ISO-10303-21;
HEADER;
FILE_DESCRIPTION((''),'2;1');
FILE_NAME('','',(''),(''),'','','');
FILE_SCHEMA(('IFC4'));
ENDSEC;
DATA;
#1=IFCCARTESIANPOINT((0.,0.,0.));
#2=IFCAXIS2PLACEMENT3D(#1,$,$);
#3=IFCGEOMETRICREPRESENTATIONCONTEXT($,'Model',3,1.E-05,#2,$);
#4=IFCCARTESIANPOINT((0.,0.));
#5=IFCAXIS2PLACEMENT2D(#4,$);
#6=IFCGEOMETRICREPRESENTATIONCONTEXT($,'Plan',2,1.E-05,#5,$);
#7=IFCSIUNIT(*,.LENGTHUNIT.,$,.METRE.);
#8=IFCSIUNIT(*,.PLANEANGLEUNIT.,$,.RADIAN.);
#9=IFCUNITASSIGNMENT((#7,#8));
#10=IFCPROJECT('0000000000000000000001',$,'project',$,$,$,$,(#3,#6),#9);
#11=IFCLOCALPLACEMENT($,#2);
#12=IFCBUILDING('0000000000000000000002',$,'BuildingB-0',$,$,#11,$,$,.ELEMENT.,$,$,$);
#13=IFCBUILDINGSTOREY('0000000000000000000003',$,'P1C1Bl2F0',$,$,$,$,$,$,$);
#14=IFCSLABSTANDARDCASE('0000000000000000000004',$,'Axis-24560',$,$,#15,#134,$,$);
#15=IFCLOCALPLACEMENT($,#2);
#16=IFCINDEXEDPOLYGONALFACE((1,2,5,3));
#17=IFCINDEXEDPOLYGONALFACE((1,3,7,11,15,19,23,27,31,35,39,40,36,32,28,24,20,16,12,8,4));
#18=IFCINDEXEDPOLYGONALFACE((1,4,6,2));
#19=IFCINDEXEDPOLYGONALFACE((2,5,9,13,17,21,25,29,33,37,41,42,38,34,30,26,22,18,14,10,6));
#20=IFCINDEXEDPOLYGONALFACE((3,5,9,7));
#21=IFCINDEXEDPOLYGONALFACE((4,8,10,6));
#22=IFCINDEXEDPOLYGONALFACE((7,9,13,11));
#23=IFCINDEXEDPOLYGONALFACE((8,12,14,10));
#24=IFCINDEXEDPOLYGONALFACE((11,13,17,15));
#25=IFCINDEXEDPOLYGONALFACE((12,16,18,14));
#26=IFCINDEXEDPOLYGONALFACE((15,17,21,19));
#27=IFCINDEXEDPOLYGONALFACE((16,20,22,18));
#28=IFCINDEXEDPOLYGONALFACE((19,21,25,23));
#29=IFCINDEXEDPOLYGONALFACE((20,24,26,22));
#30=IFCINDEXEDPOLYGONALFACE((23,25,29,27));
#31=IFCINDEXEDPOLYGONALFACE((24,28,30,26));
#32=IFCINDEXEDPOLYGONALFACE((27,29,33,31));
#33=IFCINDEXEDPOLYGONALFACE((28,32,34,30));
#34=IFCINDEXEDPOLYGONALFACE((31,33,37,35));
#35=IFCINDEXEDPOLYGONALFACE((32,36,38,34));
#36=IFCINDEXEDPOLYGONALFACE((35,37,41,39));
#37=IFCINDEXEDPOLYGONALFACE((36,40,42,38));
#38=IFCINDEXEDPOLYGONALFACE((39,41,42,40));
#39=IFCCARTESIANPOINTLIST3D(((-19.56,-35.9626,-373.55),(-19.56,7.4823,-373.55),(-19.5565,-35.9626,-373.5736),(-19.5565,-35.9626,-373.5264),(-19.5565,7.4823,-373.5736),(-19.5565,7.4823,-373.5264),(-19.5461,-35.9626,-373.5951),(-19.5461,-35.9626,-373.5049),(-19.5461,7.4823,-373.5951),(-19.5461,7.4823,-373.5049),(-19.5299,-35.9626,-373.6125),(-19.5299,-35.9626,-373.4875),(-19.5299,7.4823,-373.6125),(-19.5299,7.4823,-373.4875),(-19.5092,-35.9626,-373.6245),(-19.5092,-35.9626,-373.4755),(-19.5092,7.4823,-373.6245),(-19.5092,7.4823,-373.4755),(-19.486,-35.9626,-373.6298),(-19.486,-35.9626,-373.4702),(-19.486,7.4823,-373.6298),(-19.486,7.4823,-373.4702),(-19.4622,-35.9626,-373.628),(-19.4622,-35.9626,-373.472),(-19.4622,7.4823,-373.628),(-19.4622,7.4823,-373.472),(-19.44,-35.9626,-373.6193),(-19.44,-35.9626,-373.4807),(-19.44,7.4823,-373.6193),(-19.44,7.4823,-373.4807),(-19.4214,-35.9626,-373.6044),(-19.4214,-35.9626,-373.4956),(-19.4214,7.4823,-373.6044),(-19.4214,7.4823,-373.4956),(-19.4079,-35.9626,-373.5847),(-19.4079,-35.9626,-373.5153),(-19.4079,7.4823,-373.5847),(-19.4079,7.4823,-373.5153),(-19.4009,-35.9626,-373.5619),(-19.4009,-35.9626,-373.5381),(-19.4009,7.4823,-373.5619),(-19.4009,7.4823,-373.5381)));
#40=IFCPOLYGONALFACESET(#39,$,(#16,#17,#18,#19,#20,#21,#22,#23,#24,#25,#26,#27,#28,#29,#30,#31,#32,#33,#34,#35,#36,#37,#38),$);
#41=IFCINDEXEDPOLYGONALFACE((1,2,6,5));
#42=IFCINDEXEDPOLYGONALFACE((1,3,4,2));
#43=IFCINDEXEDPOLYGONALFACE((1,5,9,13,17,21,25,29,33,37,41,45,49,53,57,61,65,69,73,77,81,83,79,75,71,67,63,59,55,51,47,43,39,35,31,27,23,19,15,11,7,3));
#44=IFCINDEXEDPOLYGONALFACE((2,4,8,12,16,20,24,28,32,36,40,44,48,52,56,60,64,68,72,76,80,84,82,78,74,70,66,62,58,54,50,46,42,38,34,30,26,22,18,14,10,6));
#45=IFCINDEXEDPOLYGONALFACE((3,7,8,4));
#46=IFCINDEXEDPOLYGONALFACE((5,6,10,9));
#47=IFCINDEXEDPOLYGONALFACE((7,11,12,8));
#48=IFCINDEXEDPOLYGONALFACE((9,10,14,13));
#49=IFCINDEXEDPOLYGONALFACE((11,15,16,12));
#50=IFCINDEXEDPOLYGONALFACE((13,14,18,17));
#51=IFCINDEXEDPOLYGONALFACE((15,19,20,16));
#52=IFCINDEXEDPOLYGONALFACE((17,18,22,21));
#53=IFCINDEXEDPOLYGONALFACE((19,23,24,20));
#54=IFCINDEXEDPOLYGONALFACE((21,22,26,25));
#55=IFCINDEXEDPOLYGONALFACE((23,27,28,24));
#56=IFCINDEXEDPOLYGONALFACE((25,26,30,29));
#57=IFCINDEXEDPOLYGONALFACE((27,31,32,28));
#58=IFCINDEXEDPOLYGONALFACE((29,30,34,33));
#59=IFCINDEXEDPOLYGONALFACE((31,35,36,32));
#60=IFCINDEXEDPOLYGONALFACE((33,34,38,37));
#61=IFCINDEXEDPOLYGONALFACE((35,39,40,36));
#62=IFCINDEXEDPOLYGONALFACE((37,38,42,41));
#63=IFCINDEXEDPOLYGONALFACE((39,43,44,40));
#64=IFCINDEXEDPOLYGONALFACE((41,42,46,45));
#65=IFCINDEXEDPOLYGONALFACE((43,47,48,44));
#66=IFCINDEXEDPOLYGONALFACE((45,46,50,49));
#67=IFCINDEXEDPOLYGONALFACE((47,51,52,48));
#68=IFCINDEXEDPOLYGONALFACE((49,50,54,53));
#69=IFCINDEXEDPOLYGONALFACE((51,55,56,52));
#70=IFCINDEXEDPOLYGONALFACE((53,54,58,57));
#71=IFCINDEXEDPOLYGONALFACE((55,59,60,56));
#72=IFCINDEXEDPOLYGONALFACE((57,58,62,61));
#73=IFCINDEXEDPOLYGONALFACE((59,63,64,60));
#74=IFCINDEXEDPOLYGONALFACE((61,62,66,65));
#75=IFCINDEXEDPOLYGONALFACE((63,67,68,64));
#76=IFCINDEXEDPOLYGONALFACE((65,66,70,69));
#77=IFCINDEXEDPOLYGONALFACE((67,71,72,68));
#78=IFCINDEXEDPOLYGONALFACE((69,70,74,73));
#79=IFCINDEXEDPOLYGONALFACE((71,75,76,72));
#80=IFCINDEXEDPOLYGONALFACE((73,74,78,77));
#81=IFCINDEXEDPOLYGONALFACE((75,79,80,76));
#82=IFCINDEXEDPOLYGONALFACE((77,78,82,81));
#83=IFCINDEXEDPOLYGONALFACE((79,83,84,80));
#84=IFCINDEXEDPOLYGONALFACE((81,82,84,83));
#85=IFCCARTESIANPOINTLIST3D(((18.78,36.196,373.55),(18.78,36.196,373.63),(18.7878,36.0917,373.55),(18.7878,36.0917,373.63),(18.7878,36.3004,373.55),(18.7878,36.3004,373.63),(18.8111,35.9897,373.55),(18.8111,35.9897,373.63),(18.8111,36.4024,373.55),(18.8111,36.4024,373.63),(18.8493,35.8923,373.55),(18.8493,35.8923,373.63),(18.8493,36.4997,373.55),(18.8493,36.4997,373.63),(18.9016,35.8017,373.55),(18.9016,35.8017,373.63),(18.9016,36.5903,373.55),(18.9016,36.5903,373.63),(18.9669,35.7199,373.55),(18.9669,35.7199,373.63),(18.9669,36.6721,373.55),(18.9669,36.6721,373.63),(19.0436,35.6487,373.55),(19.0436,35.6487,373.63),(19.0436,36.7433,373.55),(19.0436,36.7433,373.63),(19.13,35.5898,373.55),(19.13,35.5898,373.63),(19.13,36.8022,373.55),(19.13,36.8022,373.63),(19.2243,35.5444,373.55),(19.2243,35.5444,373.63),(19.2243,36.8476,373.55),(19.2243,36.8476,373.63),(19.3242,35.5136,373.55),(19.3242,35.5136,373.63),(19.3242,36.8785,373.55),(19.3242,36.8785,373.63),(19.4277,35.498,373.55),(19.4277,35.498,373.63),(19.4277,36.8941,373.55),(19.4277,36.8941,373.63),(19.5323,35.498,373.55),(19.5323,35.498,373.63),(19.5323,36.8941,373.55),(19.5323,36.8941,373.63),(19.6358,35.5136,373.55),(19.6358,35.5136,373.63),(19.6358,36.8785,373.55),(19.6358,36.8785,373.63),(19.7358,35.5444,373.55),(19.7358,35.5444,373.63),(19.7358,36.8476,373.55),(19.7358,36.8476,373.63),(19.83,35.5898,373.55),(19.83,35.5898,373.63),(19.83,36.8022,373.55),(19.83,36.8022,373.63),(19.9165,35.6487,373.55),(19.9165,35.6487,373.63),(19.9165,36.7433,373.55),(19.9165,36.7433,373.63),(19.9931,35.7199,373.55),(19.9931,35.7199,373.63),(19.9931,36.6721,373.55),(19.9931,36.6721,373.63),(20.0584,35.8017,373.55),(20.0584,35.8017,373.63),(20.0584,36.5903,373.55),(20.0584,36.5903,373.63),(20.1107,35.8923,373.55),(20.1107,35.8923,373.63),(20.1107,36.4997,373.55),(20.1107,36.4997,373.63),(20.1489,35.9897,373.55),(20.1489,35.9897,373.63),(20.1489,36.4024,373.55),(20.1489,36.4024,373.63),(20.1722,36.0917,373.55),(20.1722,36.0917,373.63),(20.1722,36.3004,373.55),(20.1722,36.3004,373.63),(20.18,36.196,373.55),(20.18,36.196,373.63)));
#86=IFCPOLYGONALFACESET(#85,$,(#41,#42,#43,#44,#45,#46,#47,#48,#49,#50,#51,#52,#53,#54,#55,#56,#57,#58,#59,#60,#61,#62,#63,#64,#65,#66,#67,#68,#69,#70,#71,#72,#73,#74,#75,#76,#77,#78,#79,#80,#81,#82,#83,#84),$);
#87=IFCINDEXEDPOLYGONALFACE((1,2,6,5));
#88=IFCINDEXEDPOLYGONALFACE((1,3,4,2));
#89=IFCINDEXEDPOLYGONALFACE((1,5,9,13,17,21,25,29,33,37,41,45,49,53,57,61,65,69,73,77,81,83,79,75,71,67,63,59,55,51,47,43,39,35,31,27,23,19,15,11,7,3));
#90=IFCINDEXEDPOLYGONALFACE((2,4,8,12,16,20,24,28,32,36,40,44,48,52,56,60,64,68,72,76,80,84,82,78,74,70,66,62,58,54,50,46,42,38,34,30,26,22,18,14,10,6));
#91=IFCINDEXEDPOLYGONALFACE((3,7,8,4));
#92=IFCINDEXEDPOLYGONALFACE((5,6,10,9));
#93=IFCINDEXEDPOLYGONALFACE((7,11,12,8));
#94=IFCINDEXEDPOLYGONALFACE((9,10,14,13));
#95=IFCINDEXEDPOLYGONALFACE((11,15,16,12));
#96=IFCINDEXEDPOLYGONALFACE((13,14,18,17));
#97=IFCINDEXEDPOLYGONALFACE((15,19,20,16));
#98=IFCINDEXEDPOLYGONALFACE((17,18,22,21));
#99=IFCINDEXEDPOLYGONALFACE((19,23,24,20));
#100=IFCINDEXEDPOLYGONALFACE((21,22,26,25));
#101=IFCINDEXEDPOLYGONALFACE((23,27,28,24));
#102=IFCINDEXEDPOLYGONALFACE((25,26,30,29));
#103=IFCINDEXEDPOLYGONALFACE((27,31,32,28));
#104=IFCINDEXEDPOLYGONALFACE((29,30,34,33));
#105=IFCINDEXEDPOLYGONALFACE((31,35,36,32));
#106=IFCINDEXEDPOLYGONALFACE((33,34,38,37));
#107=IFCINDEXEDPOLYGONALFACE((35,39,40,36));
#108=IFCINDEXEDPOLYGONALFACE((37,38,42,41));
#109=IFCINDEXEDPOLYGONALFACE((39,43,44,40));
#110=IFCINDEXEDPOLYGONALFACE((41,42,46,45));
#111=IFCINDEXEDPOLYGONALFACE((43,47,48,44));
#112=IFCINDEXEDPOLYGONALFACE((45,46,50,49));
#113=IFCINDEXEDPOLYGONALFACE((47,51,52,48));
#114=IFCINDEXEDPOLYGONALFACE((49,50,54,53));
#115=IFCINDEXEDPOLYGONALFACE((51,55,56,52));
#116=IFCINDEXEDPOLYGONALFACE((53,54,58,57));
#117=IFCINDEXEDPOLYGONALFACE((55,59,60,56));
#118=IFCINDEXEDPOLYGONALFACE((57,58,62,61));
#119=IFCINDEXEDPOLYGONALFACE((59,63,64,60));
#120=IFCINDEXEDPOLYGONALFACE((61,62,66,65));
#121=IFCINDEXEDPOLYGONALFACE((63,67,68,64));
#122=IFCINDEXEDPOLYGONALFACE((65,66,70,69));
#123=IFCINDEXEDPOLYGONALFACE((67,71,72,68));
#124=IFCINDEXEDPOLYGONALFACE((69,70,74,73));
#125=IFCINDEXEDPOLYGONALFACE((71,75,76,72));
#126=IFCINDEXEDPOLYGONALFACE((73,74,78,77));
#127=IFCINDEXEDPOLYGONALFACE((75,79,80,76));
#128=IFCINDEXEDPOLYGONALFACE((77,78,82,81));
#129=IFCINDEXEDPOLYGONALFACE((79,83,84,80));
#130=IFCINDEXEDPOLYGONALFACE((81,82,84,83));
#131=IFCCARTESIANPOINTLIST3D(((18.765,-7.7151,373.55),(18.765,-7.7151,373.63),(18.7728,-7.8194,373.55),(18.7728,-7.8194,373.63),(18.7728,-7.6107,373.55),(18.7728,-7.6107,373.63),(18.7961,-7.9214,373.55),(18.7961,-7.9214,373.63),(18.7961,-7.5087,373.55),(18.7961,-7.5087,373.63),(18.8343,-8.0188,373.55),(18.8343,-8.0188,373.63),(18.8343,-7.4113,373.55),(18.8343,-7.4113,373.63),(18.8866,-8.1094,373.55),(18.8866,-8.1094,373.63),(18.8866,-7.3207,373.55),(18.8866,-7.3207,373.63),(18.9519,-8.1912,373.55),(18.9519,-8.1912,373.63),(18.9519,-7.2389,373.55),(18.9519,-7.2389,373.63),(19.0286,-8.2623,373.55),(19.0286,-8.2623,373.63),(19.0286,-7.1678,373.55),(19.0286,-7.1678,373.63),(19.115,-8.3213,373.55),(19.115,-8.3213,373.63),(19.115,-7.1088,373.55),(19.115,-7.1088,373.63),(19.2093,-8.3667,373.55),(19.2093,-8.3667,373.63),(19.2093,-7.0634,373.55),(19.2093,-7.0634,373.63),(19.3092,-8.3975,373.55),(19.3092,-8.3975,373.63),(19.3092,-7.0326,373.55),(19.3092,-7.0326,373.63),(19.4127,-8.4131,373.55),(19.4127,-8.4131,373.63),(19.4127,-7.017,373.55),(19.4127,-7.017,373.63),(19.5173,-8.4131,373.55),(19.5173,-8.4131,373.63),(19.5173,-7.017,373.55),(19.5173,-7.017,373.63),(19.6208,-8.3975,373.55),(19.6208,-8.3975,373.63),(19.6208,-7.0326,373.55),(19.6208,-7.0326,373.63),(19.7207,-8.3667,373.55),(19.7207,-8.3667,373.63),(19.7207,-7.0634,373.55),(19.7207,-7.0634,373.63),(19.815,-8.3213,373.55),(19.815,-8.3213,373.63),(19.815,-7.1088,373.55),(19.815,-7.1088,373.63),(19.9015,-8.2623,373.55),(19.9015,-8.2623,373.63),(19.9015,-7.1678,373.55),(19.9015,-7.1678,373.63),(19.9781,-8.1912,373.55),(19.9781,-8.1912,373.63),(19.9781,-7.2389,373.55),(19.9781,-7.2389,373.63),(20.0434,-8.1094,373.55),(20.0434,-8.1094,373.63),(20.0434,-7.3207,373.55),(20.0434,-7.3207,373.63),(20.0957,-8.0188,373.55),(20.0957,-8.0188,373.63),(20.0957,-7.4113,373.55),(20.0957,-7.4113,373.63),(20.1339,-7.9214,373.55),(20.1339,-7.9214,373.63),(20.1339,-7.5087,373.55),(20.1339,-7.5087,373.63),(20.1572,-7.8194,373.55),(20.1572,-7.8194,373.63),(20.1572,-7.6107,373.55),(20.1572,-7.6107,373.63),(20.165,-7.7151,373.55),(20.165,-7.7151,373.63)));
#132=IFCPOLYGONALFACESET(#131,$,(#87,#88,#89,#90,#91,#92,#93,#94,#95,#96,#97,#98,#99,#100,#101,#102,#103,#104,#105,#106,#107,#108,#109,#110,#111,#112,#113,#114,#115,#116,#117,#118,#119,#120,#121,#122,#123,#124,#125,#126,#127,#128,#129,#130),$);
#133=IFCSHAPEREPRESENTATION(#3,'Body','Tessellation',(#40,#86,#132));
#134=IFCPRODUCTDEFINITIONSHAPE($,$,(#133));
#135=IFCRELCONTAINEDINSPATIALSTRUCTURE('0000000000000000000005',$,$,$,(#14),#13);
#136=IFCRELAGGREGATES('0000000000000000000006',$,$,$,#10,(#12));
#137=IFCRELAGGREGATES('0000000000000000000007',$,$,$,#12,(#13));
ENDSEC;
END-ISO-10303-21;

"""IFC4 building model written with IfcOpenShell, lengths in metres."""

from ifc_helpers import new_model, entity, si_unit, frame, origin, origin_2d, place, context, project, spatial, circle, extrude, element, save


model = new_model("IFC4")

# Units and contexts
model_context = context("Model", 3, precision=1e-05, world=origin())
plan_context = context("Plan", 2, precision=1e-05, world=origin_2d())
ifc_project = project(units=[si_unit("LENGTHUNIT", "METRE"), si_unit("PLANEANGLEUNIT", "RADIAN")], contexts=[model_context, plan_context])

# Building, storey
building_placement = place(None, origin())
building = spatial("IfcBuilding", under=ifc_project, at=building_placement, Name="BuildingB-0", CompositionType="ELEMENT")
storey = spatial("IfcBuildingStorey", under=building, Name="P1C1Bl2F0")

# Slab
element("IfcSlabStandardCase", 1, inside=storey, Name="Axis-24560", context=model_context, shape_type="AdvancedSweptSolid", body=[
    entity("IfcSurfaceCurveSweptAreaSolid", entity("IfcCircleProfileDef", "AREA", None, None, 0.08), None, entity("IfcPolyline", [entity("IfcCartesianPoint", [19.48, 35.9626, 373.55]), entity("IfcCartesianPoint", [19.48, -7.4823, 373.55])]), None, None, entity("IfcPlane", entity("IfcAxis2Placement3D", entity("IfcCartesianPoint", [19.48, 35.9626, 373.55]), entity("IfcDirection", [0.0, 0.0, 1.0]), entity("IfcDirection", [1.0, 0.0, 0.0])))),
    extrude(circle(Radius=0.7), frame((19.48, 36.196, 373.55)), (0.0, 0.0, 1.0), 0.08),
    extrude(circle(Radius=0.7), frame((19.465, -7.7151, 373.55)), (0.0, 0.0, 1.0), 0.08),
])

save(model, "model.ifc")
